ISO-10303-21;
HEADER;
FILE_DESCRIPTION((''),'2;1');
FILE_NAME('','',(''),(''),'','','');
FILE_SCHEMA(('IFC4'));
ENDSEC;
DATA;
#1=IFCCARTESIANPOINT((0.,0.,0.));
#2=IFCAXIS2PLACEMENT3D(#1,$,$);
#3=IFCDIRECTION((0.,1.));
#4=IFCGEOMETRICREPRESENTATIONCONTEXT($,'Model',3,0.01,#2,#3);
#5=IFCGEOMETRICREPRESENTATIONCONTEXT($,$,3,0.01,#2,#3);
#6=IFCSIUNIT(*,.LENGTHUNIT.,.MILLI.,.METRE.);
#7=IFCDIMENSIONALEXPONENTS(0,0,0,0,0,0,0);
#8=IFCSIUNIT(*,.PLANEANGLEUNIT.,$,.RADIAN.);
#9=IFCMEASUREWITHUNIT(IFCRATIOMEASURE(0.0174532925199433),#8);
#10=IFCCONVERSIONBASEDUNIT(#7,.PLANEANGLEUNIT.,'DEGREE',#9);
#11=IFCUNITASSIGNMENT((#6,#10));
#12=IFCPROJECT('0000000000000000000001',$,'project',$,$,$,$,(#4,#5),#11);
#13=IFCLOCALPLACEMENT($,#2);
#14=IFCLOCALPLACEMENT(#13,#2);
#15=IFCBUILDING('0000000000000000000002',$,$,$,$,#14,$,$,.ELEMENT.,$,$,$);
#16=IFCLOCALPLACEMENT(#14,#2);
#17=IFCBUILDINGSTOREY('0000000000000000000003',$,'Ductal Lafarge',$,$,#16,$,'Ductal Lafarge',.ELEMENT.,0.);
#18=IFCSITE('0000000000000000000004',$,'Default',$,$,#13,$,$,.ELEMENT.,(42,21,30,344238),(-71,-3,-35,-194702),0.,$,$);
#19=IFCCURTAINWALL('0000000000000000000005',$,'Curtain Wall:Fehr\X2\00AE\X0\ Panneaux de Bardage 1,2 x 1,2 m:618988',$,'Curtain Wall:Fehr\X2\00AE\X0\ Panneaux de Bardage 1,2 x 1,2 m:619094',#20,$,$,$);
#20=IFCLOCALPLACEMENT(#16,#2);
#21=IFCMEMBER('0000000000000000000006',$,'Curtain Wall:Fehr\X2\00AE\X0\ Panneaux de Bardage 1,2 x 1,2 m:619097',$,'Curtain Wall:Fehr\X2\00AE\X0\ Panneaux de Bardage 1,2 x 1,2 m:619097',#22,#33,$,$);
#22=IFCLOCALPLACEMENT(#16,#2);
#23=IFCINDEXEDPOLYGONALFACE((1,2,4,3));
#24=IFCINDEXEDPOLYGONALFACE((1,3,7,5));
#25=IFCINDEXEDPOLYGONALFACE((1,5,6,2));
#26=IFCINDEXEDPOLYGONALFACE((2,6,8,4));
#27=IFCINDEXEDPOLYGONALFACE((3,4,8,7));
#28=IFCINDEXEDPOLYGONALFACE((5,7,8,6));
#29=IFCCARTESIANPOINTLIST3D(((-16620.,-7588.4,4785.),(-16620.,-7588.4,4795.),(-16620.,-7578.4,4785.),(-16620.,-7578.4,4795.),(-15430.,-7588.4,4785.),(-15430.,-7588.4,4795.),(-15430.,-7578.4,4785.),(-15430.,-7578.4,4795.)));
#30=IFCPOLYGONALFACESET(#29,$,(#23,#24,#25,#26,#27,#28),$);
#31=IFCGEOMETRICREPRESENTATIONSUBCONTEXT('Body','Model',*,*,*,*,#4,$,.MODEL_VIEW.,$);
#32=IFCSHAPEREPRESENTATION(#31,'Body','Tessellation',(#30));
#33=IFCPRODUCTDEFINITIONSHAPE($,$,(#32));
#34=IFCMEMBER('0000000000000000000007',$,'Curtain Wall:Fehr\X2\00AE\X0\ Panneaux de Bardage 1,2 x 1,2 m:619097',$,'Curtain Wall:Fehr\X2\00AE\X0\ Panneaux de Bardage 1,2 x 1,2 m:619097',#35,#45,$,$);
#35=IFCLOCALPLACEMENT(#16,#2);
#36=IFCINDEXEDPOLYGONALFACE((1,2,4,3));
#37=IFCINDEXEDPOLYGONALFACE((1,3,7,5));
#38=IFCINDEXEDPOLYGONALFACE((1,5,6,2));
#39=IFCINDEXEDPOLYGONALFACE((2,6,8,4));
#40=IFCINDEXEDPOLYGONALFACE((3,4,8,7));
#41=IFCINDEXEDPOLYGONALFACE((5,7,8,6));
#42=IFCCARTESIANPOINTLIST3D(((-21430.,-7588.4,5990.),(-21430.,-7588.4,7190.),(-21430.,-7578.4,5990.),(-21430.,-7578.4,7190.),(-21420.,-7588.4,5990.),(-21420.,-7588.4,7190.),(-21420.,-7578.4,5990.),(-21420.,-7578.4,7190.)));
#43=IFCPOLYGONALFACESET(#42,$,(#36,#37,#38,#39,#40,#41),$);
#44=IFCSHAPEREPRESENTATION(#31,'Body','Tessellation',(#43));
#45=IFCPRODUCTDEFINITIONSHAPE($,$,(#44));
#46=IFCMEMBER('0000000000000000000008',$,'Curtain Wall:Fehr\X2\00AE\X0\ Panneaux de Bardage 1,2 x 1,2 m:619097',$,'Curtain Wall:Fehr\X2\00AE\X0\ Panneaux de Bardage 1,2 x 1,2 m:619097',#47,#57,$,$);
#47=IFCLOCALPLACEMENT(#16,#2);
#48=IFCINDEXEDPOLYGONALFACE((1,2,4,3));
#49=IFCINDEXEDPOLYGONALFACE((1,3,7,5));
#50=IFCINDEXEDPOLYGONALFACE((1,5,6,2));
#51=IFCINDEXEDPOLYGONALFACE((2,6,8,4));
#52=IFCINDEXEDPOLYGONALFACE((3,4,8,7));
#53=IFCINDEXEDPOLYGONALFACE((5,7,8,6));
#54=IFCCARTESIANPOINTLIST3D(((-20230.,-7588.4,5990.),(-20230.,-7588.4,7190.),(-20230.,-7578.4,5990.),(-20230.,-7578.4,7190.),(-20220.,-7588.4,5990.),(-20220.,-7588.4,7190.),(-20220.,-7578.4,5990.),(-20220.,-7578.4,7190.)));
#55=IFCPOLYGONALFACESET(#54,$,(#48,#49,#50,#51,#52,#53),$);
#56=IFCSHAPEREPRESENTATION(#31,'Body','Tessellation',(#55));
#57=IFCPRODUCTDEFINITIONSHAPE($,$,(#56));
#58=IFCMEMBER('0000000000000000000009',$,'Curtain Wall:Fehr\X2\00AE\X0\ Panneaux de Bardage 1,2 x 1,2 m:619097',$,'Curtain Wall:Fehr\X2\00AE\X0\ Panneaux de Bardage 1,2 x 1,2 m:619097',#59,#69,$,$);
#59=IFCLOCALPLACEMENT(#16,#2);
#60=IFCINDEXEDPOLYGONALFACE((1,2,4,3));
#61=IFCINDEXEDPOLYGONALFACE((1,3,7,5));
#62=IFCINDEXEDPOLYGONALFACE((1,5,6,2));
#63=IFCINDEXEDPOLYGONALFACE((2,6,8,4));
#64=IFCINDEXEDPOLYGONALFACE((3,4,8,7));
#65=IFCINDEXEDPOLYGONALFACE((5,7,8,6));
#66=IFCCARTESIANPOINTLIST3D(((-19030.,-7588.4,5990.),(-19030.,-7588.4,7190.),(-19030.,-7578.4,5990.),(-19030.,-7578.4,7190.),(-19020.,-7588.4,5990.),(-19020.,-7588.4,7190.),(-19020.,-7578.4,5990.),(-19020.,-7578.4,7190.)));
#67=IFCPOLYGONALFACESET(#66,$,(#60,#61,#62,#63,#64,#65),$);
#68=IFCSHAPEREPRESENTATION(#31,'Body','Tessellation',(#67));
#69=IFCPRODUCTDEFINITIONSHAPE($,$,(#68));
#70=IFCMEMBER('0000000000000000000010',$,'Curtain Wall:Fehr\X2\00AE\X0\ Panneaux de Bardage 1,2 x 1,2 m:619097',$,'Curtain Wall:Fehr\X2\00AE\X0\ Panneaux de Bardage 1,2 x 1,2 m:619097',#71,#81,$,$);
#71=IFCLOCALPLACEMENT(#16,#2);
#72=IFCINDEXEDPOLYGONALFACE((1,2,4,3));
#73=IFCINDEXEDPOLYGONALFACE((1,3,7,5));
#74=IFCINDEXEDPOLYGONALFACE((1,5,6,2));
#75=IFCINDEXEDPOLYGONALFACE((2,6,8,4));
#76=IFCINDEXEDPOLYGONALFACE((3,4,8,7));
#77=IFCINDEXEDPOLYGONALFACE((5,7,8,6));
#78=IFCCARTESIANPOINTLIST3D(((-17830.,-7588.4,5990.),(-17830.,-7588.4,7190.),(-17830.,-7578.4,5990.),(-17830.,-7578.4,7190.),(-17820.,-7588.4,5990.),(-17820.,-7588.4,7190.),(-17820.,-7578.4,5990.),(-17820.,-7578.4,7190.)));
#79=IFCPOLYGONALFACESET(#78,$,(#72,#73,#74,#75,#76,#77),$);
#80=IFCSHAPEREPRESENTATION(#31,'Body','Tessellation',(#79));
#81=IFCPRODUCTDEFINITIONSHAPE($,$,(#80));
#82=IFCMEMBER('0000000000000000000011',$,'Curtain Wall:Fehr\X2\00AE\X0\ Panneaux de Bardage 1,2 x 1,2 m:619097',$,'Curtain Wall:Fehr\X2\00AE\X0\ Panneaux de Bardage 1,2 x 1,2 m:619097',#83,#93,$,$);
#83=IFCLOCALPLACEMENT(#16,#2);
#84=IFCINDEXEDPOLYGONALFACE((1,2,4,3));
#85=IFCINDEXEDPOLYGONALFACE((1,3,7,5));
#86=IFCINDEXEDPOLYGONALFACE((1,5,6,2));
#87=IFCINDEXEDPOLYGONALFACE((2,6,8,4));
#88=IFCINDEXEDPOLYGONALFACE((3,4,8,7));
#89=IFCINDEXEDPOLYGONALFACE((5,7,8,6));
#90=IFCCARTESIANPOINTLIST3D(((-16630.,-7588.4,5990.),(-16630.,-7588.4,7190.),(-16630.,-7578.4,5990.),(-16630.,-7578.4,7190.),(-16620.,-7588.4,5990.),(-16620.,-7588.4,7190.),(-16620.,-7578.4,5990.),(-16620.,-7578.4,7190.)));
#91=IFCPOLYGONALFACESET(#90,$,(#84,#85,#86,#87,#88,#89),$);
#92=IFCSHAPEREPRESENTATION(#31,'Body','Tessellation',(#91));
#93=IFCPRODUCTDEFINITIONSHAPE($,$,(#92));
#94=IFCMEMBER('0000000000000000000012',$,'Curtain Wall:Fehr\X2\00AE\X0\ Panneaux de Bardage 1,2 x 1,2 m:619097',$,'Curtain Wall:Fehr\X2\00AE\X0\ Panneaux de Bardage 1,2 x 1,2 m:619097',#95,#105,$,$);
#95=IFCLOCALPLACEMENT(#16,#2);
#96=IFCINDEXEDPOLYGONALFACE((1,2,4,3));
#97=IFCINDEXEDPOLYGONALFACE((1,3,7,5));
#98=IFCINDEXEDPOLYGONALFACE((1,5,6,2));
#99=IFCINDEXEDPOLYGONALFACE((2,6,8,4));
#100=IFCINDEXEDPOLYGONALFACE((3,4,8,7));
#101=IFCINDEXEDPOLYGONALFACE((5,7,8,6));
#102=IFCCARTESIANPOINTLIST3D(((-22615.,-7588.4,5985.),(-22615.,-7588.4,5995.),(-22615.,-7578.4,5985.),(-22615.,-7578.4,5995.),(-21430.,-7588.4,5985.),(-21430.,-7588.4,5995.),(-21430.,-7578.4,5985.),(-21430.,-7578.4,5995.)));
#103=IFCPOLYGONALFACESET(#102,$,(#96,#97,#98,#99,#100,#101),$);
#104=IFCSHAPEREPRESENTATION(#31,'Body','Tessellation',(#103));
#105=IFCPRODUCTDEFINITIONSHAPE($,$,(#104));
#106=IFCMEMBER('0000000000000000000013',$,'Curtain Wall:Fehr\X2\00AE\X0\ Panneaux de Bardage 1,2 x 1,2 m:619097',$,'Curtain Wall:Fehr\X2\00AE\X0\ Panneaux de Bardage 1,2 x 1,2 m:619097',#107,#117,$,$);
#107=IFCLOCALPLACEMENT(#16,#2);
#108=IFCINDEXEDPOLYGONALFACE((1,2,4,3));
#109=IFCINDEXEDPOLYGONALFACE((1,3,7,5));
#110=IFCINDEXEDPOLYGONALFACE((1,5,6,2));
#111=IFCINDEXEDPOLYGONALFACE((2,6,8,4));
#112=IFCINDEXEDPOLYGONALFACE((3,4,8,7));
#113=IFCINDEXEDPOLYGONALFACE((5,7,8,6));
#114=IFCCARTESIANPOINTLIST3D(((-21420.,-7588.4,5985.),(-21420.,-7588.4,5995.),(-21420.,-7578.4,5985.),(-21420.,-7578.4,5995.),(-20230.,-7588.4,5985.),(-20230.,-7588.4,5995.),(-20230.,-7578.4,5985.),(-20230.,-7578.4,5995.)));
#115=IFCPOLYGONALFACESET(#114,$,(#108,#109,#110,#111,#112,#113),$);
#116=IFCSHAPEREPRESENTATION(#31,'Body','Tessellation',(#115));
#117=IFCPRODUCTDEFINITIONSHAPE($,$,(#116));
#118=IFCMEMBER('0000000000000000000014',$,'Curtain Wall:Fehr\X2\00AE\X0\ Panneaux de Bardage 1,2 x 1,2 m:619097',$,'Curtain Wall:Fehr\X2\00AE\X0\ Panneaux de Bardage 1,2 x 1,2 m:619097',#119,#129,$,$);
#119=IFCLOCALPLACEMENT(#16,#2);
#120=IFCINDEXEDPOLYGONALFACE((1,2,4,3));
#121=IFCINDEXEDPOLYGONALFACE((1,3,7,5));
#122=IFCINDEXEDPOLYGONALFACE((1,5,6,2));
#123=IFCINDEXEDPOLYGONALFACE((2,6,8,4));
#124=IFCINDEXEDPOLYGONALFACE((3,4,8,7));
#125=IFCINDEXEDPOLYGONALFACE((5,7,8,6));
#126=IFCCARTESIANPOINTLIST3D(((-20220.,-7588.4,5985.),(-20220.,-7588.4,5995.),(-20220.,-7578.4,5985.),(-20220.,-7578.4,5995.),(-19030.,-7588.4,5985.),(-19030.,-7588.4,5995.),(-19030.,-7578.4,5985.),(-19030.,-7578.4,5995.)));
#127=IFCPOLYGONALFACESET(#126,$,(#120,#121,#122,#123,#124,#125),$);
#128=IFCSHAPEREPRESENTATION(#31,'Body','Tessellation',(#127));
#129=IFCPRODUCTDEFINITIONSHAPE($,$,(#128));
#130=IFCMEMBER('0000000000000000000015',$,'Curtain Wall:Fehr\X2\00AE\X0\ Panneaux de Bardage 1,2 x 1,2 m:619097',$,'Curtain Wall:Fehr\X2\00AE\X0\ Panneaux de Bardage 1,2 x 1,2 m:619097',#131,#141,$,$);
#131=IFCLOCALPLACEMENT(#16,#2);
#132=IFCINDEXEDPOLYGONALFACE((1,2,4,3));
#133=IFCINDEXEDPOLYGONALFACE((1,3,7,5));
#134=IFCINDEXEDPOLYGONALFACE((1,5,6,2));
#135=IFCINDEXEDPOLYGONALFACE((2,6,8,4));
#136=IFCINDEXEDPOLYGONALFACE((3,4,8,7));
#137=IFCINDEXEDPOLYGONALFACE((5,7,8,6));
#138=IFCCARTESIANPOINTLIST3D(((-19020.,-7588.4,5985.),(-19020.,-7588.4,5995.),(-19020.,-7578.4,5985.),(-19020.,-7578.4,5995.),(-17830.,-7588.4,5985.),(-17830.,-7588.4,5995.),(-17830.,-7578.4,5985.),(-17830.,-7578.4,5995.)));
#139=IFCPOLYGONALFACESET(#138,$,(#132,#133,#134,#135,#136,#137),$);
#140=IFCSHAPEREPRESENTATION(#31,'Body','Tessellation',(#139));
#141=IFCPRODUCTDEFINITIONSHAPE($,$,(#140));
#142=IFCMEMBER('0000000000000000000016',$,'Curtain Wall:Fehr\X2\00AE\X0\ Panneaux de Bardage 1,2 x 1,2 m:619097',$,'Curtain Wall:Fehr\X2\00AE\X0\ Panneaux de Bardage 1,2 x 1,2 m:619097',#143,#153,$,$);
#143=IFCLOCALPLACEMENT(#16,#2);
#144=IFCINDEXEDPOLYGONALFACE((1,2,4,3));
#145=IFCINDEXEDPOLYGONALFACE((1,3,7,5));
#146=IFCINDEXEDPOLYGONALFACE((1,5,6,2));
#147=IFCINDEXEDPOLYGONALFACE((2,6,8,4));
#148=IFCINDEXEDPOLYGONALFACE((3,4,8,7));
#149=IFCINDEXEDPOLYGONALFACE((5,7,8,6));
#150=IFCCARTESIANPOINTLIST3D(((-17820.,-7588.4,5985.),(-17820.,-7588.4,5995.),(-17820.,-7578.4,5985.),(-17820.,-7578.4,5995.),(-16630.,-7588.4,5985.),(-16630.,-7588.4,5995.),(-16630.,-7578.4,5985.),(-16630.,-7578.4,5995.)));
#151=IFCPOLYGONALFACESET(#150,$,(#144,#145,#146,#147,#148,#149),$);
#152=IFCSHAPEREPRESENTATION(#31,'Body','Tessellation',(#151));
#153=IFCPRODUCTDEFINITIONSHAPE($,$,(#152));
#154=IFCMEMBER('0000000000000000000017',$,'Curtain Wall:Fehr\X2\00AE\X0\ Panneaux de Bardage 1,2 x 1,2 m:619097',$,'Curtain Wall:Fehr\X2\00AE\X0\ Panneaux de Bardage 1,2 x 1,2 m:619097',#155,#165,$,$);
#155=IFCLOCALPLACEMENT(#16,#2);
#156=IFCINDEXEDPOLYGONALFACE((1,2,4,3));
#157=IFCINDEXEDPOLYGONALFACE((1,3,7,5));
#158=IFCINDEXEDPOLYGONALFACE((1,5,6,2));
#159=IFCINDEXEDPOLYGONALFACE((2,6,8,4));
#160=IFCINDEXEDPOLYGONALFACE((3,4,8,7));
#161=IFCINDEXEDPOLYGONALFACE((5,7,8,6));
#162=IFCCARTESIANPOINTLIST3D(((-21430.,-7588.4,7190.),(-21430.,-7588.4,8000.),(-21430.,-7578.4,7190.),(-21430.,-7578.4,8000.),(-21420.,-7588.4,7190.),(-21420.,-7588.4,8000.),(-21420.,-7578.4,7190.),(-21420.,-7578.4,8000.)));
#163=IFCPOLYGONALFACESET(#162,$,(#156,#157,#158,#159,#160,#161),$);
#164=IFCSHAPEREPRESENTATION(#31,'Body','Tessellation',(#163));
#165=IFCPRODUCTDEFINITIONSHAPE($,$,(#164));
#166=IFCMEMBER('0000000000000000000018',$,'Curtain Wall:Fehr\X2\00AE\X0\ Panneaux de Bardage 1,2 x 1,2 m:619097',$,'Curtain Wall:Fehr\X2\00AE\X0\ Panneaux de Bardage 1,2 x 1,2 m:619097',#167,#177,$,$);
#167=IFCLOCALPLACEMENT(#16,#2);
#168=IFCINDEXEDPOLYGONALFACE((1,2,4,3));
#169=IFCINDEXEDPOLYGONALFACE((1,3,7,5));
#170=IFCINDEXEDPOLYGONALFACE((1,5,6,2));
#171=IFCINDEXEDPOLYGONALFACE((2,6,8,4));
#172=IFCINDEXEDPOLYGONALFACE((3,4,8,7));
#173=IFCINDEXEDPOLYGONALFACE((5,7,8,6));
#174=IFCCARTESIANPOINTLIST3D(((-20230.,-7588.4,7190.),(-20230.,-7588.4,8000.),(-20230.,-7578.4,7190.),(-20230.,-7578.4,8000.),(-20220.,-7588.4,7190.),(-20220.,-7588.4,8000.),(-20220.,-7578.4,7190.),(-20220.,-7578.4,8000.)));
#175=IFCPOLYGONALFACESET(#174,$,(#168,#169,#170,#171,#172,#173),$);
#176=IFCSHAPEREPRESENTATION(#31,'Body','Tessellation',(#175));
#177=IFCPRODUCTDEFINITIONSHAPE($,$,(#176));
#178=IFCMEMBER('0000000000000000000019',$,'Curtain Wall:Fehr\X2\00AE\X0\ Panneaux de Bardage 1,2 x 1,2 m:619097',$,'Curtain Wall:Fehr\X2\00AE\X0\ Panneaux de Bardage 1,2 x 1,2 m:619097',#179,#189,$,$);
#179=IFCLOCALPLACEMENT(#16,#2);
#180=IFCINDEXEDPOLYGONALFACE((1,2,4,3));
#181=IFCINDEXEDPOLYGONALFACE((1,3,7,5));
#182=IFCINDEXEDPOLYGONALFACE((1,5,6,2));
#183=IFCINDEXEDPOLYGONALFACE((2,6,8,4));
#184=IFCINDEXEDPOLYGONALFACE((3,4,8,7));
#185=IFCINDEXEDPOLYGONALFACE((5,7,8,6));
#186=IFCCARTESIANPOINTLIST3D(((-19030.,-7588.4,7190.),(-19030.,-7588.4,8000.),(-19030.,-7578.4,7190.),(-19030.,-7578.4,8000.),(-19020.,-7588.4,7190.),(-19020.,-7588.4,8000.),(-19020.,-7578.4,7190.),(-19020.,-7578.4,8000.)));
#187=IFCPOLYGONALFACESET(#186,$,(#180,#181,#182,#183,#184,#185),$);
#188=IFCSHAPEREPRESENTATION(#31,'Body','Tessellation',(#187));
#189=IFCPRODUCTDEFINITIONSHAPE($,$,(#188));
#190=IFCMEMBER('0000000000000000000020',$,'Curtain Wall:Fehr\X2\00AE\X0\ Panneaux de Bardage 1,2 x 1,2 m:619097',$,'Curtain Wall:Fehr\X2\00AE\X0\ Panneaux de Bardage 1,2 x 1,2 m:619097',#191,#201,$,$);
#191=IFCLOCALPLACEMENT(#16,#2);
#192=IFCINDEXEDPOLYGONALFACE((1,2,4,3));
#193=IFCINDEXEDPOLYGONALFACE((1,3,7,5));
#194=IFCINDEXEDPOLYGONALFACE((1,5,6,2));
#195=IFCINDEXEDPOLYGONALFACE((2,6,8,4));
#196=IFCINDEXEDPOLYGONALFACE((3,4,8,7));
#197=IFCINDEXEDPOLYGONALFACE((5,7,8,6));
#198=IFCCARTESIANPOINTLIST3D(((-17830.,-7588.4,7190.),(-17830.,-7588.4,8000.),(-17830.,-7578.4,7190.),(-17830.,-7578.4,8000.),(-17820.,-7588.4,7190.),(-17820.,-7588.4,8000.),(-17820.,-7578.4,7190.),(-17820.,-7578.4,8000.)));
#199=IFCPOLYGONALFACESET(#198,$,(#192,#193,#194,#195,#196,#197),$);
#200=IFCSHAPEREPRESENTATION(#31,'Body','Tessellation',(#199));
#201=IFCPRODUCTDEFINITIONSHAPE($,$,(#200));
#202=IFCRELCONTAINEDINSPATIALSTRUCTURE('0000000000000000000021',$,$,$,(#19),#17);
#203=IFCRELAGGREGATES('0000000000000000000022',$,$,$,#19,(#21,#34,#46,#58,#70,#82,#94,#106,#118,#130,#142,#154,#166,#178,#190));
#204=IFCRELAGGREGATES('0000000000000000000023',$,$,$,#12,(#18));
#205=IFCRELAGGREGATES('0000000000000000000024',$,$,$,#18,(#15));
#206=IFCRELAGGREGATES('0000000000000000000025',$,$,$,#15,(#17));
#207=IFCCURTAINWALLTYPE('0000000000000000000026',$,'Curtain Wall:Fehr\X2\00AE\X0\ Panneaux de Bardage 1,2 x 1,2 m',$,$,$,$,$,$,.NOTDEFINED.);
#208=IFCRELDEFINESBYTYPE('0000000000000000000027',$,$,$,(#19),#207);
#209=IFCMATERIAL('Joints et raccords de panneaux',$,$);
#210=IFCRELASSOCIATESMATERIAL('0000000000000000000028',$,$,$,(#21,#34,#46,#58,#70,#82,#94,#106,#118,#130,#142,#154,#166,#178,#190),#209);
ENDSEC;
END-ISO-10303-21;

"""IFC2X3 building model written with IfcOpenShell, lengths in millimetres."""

from ifc_helpers import new_model, entity, si_unit, converted_unit, direction, frame, frame_2d, origin, origin_2d_with_axis, place, context, subcontext, project, spatial, rectangle, extrude, material, type_object, element, aggregate, save


model = new_model("IFC2X3")

# Units and contexts
model_context = context("Model", 3, precision=0.01, world=origin(), true_north=direction((0.0, 1.0)))
context_of_model = context(None, 3, precision=0.01, world=origin(), true_north=direction((0.0, 1.0)))
body_context = subcontext(model_context, "Body", "Model", "MODEL_VIEW")
ifc_project = project(units=[si_unit("LENGTHUNIT", "METRE", prefix="MILLI"), converted_unit("PLANEANGLEUNIT", "DEGREE", entity("IfcRatioMeasure", 0.0174532925199433), si_unit("PLANEANGLEUNIT", "RADIAN"), dimensions=[0, 0, 0, 0, 0, 0, 0])], contexts=[model_context, context_of_model])

# Site, building, storey
site_placement = place(None, origin())
site = spatial("IfcSite", under=ifc_project, at=site_placement, Name="Default", CompositionType="ELEMENT", RefLatitude=(42, 21, 30, 344238), RefLongitude=(-71, -3, -35, -194702), RefElevation=0.0)
building_placement = place(site_placement, origin())
building = spatial("IfcBuilding", under=site, at=building_placement, CompositionType="ELEMENT")
storey_placement = place(building_placement, origin())
storey = spatial("IfcBuildingStorey", under=building, at=storey_placement, Name="Ductal Lafarge", LongName="Ductal Lafarge", CompositionType="ELEMENT", Elevation=0.0)

# Curtain wall, members
curtain_wall_type = type_object("IfcCurtainWallType", Name="Curtain Wall:Fehr® Panneaux de Bardage 1,2 x 1,2 m", PredefinedType="NOTDEFINED")
curtain_wall_placement = place(storey_placement, origin())
curtain_wall = element("IfcCurtainWall", 1, at=curtain_wall_placement, inside=storey, type_object=curtain_wall_type, Name="Curtain Wall:Fehr® Panneaux de Bardage 1,2 x 1,2 m:618988", ObjectType="Curtain Wall:Fehr® Panneaux de Bardage 1,2 x 1,2 m:619094")
ifc_material = material(Name="Joints et raccords de panneaux")
member_1_placement = place(curtain_wall_placement, frame((-16620.0, -7588.4, 4785.0)))
member_1 = element("IfcMember", 2, at=member_1_placement, material=ifc_material, Name="Curtain Wall:Fehr® Panneaux de Bardage 1,2 x 1,2 m:619097", ObjectType="Curtain Wall:Fehr® Panneaux de Bardage 1,2 x 1,2 m:619097", context=body_context, shape_type="SweptSolid", body=[
    extrude(rectangle(XDim=1190.0, YDim=10.0, at=frame_2d((0.0, 0.0), x_axis=(1.0, 0.0))), frame((595.0, 5.0, 0.0), z_axis=(0.0, 0.0, 1.0), x_axis=(-1.0, 0.0, 0.0)), (0.0, 0.0, 1.0), 10.0),
])
member_2_placement = place(curtain_wall_placement, frame((-21430.0, -7588.4, 5990.0)))
member_2 = element("IfcMember", 3, at=member_2_placement, material=ifc_material, Name="Curtain Wall:Fehr® Panneaux de Bardage 1,2 x 1,2 m:619097", ObjectType="Curtain Wall:Fehr® Panneaux de Bardage 1,2 x 1,2 m:619097", context=body_context, shape_type="SweptSolid", body=[
    extrude(rectangle(XDim=10.0, YDim=10.0, at=origin_2d_with_axis()), frame((5.0, 5.0, 0.0), z_axis=(0.0, 0.0, 1.0), x_axis=(0.0, 1.0, 0.0)), (0.0, 0.0, 1.0), 1200.0),
])
member_3_placement = place(curtain_wall_placement, frame((-20230.0, -7588.4, 5990.0)))
member_3 = element("IfcMember", 4, at=member_3_placement, material=ifc_material, Name="Curtain Wall:Fehr® Panneaux de Bardage 1,2 x 1,2 m:619097", ObjectType="Curtain Wall:Fehr® Panneaux de Bardage 1,2 x 1,2 m:619097", context=body_context, shape_type="SweptSolid", body=[
    extrude(rectangle(XDim=10.0, YDim=10.0, at=origin_2d_with_axis()), frame((5.0, 5.0, 0.0), z_axis=(0.0, 0.0, 1.0), x_axis=(0.0, 1.0, 0.0)), (0.0, 0.0, 1.0), 1200.0),
])
member_4_placement = place(curtain_wall_placement, frame((-19030.0, -7588.4, 5990.0)))
member_4 = element("IfcMember", 5, at=member_4_placement, material=ifc_material, Name="Curtain Wall:Fehr® Panneaux de Bardage 1,2 x 1,2 m:619097", ObjectType="Curtain Wall:Fehr® Panneaux de Bardage 1,2 x 1,2 m:619097", context=body_context, shape_type="SweptSolid", body=[
    extrude(rectangle(XDim=10.0, YDim=10.0, at=origin_2d_with_axis()), frame((5.0, 5.0, 0.0), z_axis=(0.0, 0.0, 1.0), x_axis=(0.0, 1.0, 0.0)), (0.0, 0.0, 1.0), 1200.0),
])
member_5_placement = place(curtain_wall_placement, frame((-17830.0, -7588.4, 5990.0)))
member_5 = element("IfcMember", 6, at=member_5_placement, material=ifc_material, Name="Curtain Wall:Fehr® Panneaux de Bardage 1,2 x 1,2 m:619097", ObjectType="Curtain Wall:Fehr® Panneaux de Bardage 1,2 x 1,2 m:619097", context=body_context, shape_type="SweptSolid", body=[
    extrude(rectangle(XDim=10.0, YDim=10.0, at=origin_2d_with_axis()), frame((5.0, 5.0, 0.0), z_axis=(0.0, 0.0, 1.0), x_axis=(0.0, 1.0, 0.0)), (0.0, 0.0, 1.0), 1200.0),
])
member_6_placement = place(curtain_wall_placement, frame((-16630.0, -7588.4, 5990.0)))
member_6 = element("IfcMember", 7, at=member_6_placement, material=ifc_material, Name="Curtain Wall:Fehr® Panneaux de Bardage 1,2 x 1,2 m:619097", ObjectType="Curtain Wall:Fehr® Panneaux de Bardage 1,2 x 1,2 m:619097", context=body_context, shape_type="SweptSolid", body=[
    extrude(rectangle(XDim=10.0, YDim=10.0, at=origin_2d_with_axis()), frame((5.0, 5.0, 0.0), z_axis=(0.0, 0.0, 1.0), x_axis=(0.0, 1.0, 0.0)), (0.0, 0.0, 1.0), 1200.0),
])
member_7_placement = place(curtain_wall_placement, frame((-22615.0, -7588.4, 5985.0)))
member_7 = element("IfcMember", 8, at=member_7_placement, material=ifc_material, Name="Curtain Wall:Fehr® Panneaux de Bardage 1,2 x 1,2 m:619097", ObjectType="Curtain Wall:Fehr® Panneaux de Bardage 1,2 x 1,2 m:619097", context=body_context, shape_type="SweptSolid", body=[
    extrude(rectangle(XDim=1185.0, YDim=10.0, at=origin_2d_with_axis()), frame((592.5, 5.0, 0.0), z_axis=(0.0, 0.0, 1.0), x_axis=(-1.0, 0.0, 0.0)), (0.0, 0.0, 1.0), 10.0),
])
member_8_placement = place(curtain_wall_placement, frame((-21420.0, -7588.4, 5985.0)))
member_8 = element("IfcMember", 9, at=member_8_placement, material=ifc_material, Name="Curtain Wall:Fehr® Panneaux de Bardage 1,2 x 1,2 m:619097", ObjectType="Curtain Wall:Fehr® Panneaux de Bardage 1,2 x 1,2 m:619097", context=body_context, shape_type="SweptSolid", body=[
    extrude(rectangle(XDim=1190.0, YDim=10.0, at=frame_2d((0.0, 0.0), x_axis=(1.0, 0.0))), frame((595.0, 5.0, 0.0), z_axis=(0.0, 0.0, 1.0), x_axis=(-1.0, 0.0, 0.0)), (0.0, 0.0, 1.0), 10.0),
])
member_9_placement = place(curtain_wall_placement, frame((-20220.0, -7588.4, 5985.0)))
member_9 = element("IfcMember", 10, at=member_9_placement, material=ifc_material, Name="Curtain Wall:Fehr® Panneaux de Bardage 1,2 x 1,2 m:619097", ObjectType="Curtain Wall:Fehr® Panneaux de Bardage 1,2 x 1,2 m:619097", context=body_context, shape_type="SweptSolid", body=[
    extrude(rectangle(XDim=1190.0, YDim=10.0, at=frame_2d((0.0, 0.0), x_axis=(1.0, 0.0))), frame((595.0, 5.0, 0.0), z_axis=(0.0, 0.0, 1.0), x_axis=(-1.0, 0.0, 0.0)), (0.0, 0.0, 1.0), 10.0),
])
member_10_placement = place(curtain_wall_placement, frame((-19020.0, -7588.4, 5985.0)))
member_10 = element("IfcMember", 11, at=member_10_placement, material=ifc_material, Name="Curtain Wall:Fehr® Panneaux de Bardage 1,2 x 1,2 m:619097", ObjectType="Curtain Wall:Fehr® Panneaux de Bardage 1,2 x 1,2 m:619097", context=body_context, shape_type="SweptSolid", body=[
    extrude(rectangle(XDim=1190.0, YDim=10.0, at=frame_2d((0.0, 0.0), x_axis=(1.0, 0.0))), frame((595.0, 5.0, 0.0), z_axis=(0.0, 0.0, 1.0), x_axis=(-1.0, 0.0, 0.0)), (0.0, 0.0, 1.0), 10.0),
])
member_11_placement = place(curtain_wall_placement, frame((-17820.0, -7588.4, 5985.0)))
member_11 = element("IfcMember", 12, at=member_11_placement, material=ifc_material, Name="Curtain Wall:Fehr® Panneaux de Bardage 1,2 x 1,2 m:619097", ObjectType="Curtain Wall:Fehr® Panneaux de Bardage 1,2 x 1,2 m:619097", context=body_context, shape_type="SweptSolid", body=[
    extrude(rectangle(XDim=1190.0, YDim=10.0, at=frame_2d((0.0, 0.0), x_axis=(1.0, 0.0))), frame((595.0, 5.0, 0.0), z_axis=(0.0, 0.0, 1.0), x_axis=(-1.0, 0.0, 0.0)), (0.0, 0.0, 1.0), 10.0),
])
member_12_placement = place(curtain_wall_placement, frame((-21430.0, -7588.4, 7190.0)))
member_12 = element("IfcMember", 13, at=member_12_placement, material=ifc_material, Name="Curtain Wall:Fehr® Panneaux de Bardage 1,2 x 1,2 m:619097", ObjectType="Curtain Wall:Fehr® Panneaux de Bardage 1,2 x 1,2 m:619097", context=body_context, shape_type="SweptSolid", body=[
    extrude(rectangle(XDim=10.0, YDim=10.0, at=frame_2d((0.0, 0.0), x_axis=(1.0, 0.0))), frame((5.0, 5.0, 0.0), z_axis=(0.0, 0.0, 1.0), x_axis=(0.0, 1.0, 0.0)), (0.0, 0.0, 1.0), 810.0),
])
member_13_placement = place(curtain_wall_placement, frame((-20230.0, -7588.4, 7190.0)))
member_13 = element("IfcMember", 14, at=member_13_placement, material=ifc_material, Name="Curtain Wall:Fehr® Panneaux de Bardage 1,2 x 1,2 m:619097", ObjectType="Curtain Wall:Fehr® Panneaux de Bardage 1,2 x 1,2 m:619097", context=body_context, shape_type="SweptSolid", body=[
    extrude(rectangle(XDim=10.0, YDim=10.0, at=frame_2d((0.0, 0.0), x_axis=(1.0, 0.0))), frame((5.0, 5.0, 0.0), z_axis=(0.0, 0.0, 1.0), x_axis=(0.0, 1.0, 0.0)), (0.0, 0.0, 1.0), 810.0),
])
member_14_placement = place(curtain_wall_placement, frame((-19030.0, -7588.4, 7190.0)))
member_14 = element("IfcMember", 15, at=member_14_placement, material=ifc_material, Name="Curtain Wall:Fehr® Panneaux de Bardage 1,2 x 1,2 m:619097", ObjectType="Curtain Wall:Fehr® Panneaux de Bardage 1,2 x 1,2 m:619097", context=body_context, shape_type="SweptSolid", body=[
    extrude(rectangle(XDim=10.0, YDim=10.0, at=frame_2d((0.0, 0.0), x_axis=(1.0, 0.0))), frame((5.0, 5.0, 0.0), z_axis=(0.0, 0.0, 1.0), x_axis=(0.0, 1.0, 0.0)), (0.0, 0.0, 1.0), 810.0),
])
member_15_placement = place(curtain_wall_placement, frame((-17830.0, -7588.4, 7190.0)))
member_15 = element("IfcMember", 16, at=member_15_placement, material=ifc_material, Name="Curtain Wall:Fehr® Panneaux de Bardage 1,2 x 1,2 m:619097", ObjectType="Curtain Wall:Fehr® Panneaux de Bardage 1,2 x 1,2 m:619097", context=body_context, shape_type="SweptSolid", body=[
    extrude(rectangle(XDim=10.0, YDim=10.0, at=frame_2d((0.0, 0.0), x_axis=(1.0, 0.0))), frame((5.0, 5.0, 0.0), z_axis=(0.0, 0.0, 1.0), x_axis=(0.0, 1.0, 0.0)), (0.0, 0.0, 1.0), 810.0),
])
aggregate(curtain_wall, [member_1, member_2, member_3, member_4, member_5, member_6, member_7, member_8, member_9, member_10, member_11, member_12, member_13, member_14, member_15])

save(model, "model.ifc")
